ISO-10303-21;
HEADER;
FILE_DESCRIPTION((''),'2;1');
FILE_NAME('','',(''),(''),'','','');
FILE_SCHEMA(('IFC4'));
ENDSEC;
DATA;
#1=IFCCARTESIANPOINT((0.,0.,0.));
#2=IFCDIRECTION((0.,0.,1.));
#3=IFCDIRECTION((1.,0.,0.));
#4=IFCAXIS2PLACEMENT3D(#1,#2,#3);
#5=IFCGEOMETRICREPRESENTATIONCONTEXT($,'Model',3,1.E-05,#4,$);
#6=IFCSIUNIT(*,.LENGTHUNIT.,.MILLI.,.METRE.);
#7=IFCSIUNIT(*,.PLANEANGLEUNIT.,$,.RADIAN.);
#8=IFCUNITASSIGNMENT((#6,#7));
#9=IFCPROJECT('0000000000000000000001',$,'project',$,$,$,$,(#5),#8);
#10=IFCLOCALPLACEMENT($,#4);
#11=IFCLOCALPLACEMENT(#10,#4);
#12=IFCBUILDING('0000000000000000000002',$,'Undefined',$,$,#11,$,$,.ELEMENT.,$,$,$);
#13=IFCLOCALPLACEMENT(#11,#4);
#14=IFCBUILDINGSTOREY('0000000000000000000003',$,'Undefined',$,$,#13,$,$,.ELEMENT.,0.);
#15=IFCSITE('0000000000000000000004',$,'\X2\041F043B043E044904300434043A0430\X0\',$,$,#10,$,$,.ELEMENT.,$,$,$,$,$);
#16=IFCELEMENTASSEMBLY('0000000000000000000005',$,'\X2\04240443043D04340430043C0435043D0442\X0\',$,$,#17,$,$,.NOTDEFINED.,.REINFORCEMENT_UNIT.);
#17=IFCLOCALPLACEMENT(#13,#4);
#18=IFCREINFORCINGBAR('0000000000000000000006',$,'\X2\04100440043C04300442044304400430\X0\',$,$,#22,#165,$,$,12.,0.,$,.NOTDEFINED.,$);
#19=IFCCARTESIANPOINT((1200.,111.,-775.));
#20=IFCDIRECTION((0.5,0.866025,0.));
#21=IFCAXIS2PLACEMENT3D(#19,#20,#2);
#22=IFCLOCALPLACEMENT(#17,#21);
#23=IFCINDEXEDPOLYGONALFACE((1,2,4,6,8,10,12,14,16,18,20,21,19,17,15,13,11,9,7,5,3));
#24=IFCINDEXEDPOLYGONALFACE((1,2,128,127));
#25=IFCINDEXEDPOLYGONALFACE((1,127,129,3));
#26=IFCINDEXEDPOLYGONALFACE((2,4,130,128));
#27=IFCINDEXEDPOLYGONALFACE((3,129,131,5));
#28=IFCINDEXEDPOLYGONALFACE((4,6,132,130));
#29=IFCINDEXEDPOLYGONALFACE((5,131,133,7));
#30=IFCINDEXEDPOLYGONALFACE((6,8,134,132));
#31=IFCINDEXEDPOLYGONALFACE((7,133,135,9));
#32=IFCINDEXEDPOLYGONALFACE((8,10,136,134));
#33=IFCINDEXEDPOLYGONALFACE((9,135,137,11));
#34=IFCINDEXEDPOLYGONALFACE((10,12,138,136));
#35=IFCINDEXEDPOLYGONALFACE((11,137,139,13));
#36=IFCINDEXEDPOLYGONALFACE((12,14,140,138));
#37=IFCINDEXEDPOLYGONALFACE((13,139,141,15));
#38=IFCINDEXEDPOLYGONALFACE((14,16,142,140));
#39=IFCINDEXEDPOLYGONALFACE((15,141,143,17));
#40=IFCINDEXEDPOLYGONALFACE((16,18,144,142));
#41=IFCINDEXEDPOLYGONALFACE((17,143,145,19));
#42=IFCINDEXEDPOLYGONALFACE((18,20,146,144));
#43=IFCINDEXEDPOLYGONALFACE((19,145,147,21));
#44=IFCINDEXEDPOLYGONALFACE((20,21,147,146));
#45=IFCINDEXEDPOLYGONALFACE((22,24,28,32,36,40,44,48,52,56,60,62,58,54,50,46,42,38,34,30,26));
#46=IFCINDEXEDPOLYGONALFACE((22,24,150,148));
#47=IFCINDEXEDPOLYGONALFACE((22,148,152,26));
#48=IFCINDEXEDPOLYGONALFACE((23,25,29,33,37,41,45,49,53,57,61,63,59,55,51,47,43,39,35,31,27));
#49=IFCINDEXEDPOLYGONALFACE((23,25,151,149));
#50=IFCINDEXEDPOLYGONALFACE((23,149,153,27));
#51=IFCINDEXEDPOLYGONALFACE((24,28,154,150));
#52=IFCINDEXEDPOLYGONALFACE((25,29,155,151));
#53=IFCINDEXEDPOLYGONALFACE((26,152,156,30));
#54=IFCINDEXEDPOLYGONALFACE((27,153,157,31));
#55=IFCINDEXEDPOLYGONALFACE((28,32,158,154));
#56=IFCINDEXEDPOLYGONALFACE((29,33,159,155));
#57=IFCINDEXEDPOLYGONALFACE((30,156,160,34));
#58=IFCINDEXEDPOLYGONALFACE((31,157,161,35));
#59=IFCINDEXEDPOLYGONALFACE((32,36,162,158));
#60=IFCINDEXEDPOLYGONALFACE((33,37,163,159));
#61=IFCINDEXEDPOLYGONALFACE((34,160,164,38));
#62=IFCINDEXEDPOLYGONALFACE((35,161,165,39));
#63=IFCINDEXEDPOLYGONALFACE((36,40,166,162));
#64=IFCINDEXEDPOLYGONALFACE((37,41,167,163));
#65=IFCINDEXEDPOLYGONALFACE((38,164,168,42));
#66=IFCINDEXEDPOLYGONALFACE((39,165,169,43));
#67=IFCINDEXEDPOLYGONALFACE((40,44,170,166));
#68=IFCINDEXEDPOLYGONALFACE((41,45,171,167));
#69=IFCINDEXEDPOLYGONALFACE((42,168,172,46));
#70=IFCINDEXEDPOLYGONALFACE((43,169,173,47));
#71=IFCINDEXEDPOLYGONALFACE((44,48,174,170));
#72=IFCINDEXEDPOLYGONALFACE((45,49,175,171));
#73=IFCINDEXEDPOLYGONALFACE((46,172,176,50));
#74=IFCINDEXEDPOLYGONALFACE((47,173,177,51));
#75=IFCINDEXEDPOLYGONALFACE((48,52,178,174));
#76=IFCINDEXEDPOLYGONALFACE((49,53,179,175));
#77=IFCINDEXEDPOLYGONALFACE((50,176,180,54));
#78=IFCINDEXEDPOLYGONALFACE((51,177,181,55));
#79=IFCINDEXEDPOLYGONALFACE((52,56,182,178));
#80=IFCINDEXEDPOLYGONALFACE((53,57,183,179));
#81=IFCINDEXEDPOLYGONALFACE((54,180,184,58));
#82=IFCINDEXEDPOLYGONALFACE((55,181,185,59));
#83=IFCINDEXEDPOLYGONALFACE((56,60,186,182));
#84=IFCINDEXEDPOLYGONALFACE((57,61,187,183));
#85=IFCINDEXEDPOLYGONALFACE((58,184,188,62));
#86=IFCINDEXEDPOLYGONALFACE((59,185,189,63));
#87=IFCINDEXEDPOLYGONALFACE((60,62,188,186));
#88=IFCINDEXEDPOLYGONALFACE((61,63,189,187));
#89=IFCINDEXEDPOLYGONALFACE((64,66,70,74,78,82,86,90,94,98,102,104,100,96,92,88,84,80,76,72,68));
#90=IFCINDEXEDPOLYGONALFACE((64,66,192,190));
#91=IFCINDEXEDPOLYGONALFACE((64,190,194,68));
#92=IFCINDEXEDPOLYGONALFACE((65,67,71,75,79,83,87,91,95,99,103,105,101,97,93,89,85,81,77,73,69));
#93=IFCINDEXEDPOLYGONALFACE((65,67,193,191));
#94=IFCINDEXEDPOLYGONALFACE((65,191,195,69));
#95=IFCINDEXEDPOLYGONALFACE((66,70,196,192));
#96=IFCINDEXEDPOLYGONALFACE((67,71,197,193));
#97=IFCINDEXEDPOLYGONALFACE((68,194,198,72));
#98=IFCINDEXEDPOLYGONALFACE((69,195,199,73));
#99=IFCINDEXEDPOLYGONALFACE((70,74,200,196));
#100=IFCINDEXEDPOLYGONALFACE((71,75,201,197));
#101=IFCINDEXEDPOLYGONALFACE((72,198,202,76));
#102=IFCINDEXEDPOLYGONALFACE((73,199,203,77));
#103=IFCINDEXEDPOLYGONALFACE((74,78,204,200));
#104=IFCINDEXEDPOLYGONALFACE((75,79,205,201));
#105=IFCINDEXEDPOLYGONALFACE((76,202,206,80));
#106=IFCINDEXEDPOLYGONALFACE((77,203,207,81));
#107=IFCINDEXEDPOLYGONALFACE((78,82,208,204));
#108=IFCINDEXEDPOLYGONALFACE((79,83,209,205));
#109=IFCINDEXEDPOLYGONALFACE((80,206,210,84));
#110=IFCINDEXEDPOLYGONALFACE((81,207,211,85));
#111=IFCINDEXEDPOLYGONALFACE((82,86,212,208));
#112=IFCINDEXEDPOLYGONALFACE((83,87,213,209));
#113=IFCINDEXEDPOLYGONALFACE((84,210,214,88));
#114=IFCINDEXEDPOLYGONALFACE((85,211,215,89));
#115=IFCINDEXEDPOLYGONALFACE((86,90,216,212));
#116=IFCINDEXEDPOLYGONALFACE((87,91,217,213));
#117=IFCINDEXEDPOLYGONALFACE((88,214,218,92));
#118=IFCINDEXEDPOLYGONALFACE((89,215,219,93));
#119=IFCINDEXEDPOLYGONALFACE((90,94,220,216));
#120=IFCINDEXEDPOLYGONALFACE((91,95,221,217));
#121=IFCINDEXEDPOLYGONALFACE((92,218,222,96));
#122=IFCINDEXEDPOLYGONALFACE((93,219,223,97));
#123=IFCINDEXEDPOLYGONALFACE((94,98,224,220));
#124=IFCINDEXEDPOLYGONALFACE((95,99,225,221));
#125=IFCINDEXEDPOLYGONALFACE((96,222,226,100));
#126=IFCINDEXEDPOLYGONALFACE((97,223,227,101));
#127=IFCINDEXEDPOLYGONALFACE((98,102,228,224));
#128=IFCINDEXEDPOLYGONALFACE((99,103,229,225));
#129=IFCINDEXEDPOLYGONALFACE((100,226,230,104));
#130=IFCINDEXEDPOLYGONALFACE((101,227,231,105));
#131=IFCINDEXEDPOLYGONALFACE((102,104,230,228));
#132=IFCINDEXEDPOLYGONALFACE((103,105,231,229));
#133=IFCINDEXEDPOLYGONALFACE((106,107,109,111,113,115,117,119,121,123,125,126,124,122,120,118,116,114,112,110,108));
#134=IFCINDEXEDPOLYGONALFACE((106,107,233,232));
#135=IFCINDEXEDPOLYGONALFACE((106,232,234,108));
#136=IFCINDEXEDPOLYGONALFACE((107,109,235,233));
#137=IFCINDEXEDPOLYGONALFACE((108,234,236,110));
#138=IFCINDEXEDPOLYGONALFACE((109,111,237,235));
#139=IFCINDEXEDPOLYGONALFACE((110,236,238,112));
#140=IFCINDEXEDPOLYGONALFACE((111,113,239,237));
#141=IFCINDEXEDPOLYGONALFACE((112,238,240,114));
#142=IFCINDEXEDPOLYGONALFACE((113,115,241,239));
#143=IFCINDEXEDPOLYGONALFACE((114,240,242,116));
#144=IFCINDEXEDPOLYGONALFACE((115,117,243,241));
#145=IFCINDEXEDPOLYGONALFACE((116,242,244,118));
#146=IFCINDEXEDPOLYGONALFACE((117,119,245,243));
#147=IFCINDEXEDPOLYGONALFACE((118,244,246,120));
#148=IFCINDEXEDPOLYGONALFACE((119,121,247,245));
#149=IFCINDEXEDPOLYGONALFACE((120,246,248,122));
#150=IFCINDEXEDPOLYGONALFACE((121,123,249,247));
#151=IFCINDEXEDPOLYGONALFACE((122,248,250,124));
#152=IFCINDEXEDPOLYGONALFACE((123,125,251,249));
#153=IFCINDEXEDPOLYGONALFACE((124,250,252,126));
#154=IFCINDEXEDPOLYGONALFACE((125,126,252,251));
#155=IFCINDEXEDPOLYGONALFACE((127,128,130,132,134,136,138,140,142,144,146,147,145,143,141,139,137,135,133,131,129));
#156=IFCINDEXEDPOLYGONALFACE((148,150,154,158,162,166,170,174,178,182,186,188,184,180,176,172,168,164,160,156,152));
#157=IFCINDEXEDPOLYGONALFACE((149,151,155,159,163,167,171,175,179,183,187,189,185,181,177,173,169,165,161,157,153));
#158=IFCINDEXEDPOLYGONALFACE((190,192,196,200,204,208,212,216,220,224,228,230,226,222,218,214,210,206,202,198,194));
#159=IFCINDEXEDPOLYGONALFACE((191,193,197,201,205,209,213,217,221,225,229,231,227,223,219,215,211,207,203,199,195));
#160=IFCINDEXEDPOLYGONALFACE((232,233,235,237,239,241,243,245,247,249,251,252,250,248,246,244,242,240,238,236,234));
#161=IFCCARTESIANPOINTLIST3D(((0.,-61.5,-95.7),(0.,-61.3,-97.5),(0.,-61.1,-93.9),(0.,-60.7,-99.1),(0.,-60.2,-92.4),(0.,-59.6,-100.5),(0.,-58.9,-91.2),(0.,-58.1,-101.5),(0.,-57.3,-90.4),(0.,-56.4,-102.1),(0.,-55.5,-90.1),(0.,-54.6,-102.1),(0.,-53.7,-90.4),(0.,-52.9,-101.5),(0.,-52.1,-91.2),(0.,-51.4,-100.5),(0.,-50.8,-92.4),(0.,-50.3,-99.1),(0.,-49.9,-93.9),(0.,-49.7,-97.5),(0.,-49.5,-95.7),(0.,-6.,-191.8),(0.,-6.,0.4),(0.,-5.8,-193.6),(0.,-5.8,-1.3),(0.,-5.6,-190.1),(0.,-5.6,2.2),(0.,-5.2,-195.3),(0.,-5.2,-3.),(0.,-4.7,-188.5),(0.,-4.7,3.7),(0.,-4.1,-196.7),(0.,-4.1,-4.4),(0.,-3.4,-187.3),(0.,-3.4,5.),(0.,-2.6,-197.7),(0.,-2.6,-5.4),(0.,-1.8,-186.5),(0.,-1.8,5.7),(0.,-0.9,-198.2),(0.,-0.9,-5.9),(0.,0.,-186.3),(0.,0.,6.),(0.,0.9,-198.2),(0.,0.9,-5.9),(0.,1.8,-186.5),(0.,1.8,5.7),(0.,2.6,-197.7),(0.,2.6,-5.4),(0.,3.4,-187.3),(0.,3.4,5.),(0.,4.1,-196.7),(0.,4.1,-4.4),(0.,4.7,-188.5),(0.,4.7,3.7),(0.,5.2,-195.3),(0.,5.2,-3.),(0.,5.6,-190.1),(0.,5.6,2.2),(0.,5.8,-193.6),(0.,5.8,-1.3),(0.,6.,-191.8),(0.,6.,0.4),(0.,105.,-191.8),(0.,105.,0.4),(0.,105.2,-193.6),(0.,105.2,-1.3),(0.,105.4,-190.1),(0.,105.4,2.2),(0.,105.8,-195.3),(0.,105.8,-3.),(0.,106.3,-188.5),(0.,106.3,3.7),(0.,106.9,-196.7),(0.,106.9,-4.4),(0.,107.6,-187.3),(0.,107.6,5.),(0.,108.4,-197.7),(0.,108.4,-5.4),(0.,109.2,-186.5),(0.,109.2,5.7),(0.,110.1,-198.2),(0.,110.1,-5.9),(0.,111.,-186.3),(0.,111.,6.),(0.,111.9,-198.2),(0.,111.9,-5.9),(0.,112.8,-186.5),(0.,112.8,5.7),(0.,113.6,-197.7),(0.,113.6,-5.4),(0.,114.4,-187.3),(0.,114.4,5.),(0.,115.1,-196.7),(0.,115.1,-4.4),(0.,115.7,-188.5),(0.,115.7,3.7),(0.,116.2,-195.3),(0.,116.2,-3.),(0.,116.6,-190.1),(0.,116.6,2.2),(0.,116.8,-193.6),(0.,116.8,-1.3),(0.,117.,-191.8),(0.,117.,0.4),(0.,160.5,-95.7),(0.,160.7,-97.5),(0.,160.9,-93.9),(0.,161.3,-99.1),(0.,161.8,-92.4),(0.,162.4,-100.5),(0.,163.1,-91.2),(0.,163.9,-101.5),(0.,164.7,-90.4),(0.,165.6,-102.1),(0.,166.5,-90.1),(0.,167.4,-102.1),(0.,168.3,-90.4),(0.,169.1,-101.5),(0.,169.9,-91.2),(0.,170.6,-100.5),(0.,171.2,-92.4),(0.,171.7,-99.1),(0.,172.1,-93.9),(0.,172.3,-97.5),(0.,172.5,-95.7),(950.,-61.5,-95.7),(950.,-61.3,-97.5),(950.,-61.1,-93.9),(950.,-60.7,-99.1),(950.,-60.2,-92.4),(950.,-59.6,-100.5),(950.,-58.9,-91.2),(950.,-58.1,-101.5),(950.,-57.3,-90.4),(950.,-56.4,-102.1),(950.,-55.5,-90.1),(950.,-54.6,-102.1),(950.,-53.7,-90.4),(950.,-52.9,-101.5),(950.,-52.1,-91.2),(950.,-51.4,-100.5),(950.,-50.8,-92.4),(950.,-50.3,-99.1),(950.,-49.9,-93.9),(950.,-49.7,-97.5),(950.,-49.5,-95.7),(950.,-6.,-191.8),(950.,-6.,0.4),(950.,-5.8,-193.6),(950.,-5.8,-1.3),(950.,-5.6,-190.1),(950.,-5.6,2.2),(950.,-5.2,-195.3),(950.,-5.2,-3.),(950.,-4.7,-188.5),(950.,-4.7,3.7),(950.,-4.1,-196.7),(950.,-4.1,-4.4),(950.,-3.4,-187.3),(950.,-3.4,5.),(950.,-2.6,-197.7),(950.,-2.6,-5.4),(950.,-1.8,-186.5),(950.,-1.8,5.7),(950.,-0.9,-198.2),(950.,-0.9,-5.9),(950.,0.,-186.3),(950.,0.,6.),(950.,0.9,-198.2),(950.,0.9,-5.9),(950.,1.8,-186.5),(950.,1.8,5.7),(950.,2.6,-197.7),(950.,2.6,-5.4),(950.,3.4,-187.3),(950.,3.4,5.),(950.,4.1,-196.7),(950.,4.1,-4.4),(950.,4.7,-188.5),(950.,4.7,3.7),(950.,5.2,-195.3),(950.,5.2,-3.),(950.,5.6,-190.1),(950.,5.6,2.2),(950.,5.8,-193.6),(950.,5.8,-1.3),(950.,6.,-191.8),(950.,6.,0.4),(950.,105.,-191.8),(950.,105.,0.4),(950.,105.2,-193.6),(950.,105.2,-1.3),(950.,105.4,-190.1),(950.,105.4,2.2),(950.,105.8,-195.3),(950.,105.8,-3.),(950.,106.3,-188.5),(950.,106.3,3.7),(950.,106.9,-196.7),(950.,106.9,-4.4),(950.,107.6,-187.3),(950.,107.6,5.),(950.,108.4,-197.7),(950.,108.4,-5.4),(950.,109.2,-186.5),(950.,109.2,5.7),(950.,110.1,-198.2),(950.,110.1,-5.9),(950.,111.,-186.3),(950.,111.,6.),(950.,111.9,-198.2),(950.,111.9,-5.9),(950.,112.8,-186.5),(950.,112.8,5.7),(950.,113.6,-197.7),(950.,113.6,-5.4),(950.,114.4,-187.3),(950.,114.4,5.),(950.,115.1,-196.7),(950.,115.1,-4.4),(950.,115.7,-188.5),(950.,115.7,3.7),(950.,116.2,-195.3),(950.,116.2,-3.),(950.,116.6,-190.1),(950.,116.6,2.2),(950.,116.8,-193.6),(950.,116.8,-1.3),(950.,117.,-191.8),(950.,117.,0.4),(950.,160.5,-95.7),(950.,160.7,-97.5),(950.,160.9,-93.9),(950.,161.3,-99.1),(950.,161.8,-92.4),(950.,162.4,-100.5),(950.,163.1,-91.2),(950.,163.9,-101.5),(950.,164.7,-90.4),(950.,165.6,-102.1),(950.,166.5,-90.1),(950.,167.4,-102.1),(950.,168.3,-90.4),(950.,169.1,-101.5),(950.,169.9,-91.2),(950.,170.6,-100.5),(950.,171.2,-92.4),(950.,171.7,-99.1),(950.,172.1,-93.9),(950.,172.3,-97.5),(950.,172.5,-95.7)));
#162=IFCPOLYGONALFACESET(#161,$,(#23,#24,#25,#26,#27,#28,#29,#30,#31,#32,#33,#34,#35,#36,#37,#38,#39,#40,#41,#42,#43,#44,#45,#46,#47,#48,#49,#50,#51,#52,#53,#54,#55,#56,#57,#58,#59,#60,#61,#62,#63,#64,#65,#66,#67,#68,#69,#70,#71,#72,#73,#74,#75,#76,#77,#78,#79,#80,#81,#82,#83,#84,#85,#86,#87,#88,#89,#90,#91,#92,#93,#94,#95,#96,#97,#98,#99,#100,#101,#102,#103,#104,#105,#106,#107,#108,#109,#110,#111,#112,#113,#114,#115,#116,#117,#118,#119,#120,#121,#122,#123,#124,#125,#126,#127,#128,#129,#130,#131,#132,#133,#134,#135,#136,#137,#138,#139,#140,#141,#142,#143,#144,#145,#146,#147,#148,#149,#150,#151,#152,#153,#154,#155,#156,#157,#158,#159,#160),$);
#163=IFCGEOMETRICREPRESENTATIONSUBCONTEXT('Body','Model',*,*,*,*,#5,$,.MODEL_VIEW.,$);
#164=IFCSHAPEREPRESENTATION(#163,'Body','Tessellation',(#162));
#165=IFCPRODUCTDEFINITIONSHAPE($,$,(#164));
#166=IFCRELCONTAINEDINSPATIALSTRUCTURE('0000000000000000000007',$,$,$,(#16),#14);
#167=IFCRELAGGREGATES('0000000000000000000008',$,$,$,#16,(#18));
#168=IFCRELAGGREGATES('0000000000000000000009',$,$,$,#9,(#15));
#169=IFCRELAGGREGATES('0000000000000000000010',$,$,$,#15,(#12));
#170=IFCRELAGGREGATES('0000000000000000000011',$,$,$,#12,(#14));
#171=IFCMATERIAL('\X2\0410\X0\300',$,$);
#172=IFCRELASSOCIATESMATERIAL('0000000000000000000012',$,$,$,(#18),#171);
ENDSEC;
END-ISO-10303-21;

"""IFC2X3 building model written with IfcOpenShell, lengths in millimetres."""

from ifc_helpers import new_model, entity, si_unit, frame, origin_with_axes, place, context, subcontext, project, spatial, source, transform, mapped, material, element, aggregate, save


model = new_model("IFC2X3")

# Units and contexts
model_context = context("Model", 3, precision=1e-05, world=origin_with_axes())
body_context = subcontext(model_context, "Body", "Model", "MODEL_VIEW")
ifc_project = project(units=[si_unit("LENGTHUNIT", "METRE", prefix="MILLI"), si_unit("PLANEANGLEUNIT", "RADIAN")], contexts=[model_context])

# Site, building, storey
site_placement = place(None, origin_with_axes())
site = spatial("IfcSite", under=ifc_project, at=site_placement, Name="Площадка", CompositionType="ELEMENT")
building_placement = place(site_placement, origin_with_axes())
building = spatial("IfcBuilding", under=site, at=building_placement, Name="Undefined", CompositionType="ELEMENT")
storey_placement = place(building_placement, origin_with_axes())
storey = spatial("IfcBuildingStorey", under=building, at=storey_placement, Name="Undefined", CompositionType="ELEMENT", Elevation=0.0)

# Element assembly, reinforcing bar
assembly_1_placement = place(storey_placement, origin_with_axes())
assembly_1 = element("IfcElementAssembly", 1, at=assembly_1_placement, inside=storey, Name="Фундамент", AssemblyPlace="NOTDEFINED", PredefinedType="REINFORCEMENT_UNIT")
ifc_material_1 = material(Name="А300")
shared_shape_1 = source(origin_with_axes(), body_context, "Body", "AdvancedSweptSolid", [
    entity("IfcSweptDiskSolid", entity("IfcTrimmedCurve", entity("IfcLine", entity("IfcCartesianPoint", [0.0, 0.0, 0.0]), entity("IfcVector", entity("IfcDirection", [1.0, 0.0, 0.0]), 1.0)), [entity("IfcParameterValue", 0.0)], [entity("IfcParameterValue", 950.0)], True, "PARAMETER"), 6.0, None, 0.0, 950.0),
])
shared_shape_2 = source(origin_with_axes(), body_context, "Body", "AdvancedSweptSolid", [
    entity("IfcSweptDiskSolid", entity("IfcTrimmedCurve", entity("IfcLine", entity("IfcCartesianPoint", [0.0, 0.0, 0.0]), entity("IfcVector", entity("IfcDirection", [1.0, 0.0, 0.0]), 1.0)), [entity("IfcParameterValue", 0.0)], [entity("IfcParameterValue", 950.0)], True, "PARAMETER"), 6.0, None, 0.0, 950.0),
])
shared_shape_3 = source(origin_with_axes(), body_context, "Body", "AdvancedSweptSolid", [
    entity("IfcSweptDiskSolid", entity("IfcTrimmedCurve", entity("IfcLine", entity("IfcCartesianPoint", [0.0, 0.0, 0.0]), entity("IfcVector", entity("IfcDirection", [1.0, 0.0, 0.0]), 1.0)), [entity("IfcParameterValue", 0.0)], [entity("IfcParameterValue", 950.0)], True, "PARAMETER"), 6.0, None, 0.0, 950.0),
])
shared_shape_4 = source(origin_with_axes(), body_context, "Body", "AdvancedSweptSolid", [
    entity("IfcSweptDiskSolid", entity("IfcTrimmedCurve", entity("IfcLine", entity("IfcCartesianPoint", [0.0, 0.0, 0.0]), entity("IfcVector", entity("IfcDirection", [1.0, 0.0, 0.0]), 1.0)), [entity("IfcParameterValue", 0.0)], [entity("IfcParameterValue", 950.0)], True, "PARAMETER"), 6.0, None, 0.0, 950.0),
])
shared_shape_5 = source(origin_with_axes(), body_context, "Body", "AdvancedSweptSolid", [
    entity("IfcSweptDiskSolid", entity("IfcTrimmedCurve", entity("IfcLine", entity("IfcCartesianPoint", [0.0, 0.0, 0.0]), entity("IfcVector", entity("IfcDirection", [1.0, 0.0, 0.0]), 1.0)), [entity("IfcParameterValue", 0.0)], [entity("IfcParameterValue", 950.0)], True, "PARAMETER"), 6.0, None, 0.0, 950.0),
])
shared_shape_6 = source(origin_with_axes(), body_context, "Body", "AdvancedSweptSolid", [
    entity("IfcSweptDiskSolid", entity("IfcTrimmedCurve", entity("IfcLine", entity("IfcCartesianPoint", [0.0, 0.0, 0.0]), entity("IfcVector", entity("IfcDirection", [1.0, 0.0, 0.0]), 1.0)), [entity("IfcParameterValue", 0.0)], [entity("IfcParameterValue", 950.0)], True, "PARAMETER"), 6.0, None, 0.0, 950.0),
])
reinforcing_bar_1_placement = place(assembly_1_placement, frame((1200.0, 111.0, -775.0), z_axis=(0.5, 0.866025, 0.0), x_axis=(0.0, 0.0, 1.0)))
reinforcing_bar_1 = element("IfcReinforcingBar", 2, at=reinforcing_bar_1_placement, material=ifc_material_1, Name="Арматура", BarRole="NOTDEFINED", CrossSectionArea=0.0, NominalDiameter=12.0, context=body_context, shape_type="MappedRepresentation", body=[
    mapped(shared_shape_1, transform((0.0, 0.0, 0.0))),
    mapped(shared_shape_2, transform((0.0, -55.5, -96.1))),
    mapped(shared_shape_3, transform((0.0, 0.0, -192.3))),
    mapped(shared_shape_4, transform((0.0, 111.0, -192.3))),
    mapped(shared_shape_5, transform((0.0, 166.5, -96.1))),
    mapped(shared_shape_6, transform((0.0, 111.0, 0.0))),
])
aggregate(assembly_1, [reinforcing_bar_1])

save(model, "model.ifc")
